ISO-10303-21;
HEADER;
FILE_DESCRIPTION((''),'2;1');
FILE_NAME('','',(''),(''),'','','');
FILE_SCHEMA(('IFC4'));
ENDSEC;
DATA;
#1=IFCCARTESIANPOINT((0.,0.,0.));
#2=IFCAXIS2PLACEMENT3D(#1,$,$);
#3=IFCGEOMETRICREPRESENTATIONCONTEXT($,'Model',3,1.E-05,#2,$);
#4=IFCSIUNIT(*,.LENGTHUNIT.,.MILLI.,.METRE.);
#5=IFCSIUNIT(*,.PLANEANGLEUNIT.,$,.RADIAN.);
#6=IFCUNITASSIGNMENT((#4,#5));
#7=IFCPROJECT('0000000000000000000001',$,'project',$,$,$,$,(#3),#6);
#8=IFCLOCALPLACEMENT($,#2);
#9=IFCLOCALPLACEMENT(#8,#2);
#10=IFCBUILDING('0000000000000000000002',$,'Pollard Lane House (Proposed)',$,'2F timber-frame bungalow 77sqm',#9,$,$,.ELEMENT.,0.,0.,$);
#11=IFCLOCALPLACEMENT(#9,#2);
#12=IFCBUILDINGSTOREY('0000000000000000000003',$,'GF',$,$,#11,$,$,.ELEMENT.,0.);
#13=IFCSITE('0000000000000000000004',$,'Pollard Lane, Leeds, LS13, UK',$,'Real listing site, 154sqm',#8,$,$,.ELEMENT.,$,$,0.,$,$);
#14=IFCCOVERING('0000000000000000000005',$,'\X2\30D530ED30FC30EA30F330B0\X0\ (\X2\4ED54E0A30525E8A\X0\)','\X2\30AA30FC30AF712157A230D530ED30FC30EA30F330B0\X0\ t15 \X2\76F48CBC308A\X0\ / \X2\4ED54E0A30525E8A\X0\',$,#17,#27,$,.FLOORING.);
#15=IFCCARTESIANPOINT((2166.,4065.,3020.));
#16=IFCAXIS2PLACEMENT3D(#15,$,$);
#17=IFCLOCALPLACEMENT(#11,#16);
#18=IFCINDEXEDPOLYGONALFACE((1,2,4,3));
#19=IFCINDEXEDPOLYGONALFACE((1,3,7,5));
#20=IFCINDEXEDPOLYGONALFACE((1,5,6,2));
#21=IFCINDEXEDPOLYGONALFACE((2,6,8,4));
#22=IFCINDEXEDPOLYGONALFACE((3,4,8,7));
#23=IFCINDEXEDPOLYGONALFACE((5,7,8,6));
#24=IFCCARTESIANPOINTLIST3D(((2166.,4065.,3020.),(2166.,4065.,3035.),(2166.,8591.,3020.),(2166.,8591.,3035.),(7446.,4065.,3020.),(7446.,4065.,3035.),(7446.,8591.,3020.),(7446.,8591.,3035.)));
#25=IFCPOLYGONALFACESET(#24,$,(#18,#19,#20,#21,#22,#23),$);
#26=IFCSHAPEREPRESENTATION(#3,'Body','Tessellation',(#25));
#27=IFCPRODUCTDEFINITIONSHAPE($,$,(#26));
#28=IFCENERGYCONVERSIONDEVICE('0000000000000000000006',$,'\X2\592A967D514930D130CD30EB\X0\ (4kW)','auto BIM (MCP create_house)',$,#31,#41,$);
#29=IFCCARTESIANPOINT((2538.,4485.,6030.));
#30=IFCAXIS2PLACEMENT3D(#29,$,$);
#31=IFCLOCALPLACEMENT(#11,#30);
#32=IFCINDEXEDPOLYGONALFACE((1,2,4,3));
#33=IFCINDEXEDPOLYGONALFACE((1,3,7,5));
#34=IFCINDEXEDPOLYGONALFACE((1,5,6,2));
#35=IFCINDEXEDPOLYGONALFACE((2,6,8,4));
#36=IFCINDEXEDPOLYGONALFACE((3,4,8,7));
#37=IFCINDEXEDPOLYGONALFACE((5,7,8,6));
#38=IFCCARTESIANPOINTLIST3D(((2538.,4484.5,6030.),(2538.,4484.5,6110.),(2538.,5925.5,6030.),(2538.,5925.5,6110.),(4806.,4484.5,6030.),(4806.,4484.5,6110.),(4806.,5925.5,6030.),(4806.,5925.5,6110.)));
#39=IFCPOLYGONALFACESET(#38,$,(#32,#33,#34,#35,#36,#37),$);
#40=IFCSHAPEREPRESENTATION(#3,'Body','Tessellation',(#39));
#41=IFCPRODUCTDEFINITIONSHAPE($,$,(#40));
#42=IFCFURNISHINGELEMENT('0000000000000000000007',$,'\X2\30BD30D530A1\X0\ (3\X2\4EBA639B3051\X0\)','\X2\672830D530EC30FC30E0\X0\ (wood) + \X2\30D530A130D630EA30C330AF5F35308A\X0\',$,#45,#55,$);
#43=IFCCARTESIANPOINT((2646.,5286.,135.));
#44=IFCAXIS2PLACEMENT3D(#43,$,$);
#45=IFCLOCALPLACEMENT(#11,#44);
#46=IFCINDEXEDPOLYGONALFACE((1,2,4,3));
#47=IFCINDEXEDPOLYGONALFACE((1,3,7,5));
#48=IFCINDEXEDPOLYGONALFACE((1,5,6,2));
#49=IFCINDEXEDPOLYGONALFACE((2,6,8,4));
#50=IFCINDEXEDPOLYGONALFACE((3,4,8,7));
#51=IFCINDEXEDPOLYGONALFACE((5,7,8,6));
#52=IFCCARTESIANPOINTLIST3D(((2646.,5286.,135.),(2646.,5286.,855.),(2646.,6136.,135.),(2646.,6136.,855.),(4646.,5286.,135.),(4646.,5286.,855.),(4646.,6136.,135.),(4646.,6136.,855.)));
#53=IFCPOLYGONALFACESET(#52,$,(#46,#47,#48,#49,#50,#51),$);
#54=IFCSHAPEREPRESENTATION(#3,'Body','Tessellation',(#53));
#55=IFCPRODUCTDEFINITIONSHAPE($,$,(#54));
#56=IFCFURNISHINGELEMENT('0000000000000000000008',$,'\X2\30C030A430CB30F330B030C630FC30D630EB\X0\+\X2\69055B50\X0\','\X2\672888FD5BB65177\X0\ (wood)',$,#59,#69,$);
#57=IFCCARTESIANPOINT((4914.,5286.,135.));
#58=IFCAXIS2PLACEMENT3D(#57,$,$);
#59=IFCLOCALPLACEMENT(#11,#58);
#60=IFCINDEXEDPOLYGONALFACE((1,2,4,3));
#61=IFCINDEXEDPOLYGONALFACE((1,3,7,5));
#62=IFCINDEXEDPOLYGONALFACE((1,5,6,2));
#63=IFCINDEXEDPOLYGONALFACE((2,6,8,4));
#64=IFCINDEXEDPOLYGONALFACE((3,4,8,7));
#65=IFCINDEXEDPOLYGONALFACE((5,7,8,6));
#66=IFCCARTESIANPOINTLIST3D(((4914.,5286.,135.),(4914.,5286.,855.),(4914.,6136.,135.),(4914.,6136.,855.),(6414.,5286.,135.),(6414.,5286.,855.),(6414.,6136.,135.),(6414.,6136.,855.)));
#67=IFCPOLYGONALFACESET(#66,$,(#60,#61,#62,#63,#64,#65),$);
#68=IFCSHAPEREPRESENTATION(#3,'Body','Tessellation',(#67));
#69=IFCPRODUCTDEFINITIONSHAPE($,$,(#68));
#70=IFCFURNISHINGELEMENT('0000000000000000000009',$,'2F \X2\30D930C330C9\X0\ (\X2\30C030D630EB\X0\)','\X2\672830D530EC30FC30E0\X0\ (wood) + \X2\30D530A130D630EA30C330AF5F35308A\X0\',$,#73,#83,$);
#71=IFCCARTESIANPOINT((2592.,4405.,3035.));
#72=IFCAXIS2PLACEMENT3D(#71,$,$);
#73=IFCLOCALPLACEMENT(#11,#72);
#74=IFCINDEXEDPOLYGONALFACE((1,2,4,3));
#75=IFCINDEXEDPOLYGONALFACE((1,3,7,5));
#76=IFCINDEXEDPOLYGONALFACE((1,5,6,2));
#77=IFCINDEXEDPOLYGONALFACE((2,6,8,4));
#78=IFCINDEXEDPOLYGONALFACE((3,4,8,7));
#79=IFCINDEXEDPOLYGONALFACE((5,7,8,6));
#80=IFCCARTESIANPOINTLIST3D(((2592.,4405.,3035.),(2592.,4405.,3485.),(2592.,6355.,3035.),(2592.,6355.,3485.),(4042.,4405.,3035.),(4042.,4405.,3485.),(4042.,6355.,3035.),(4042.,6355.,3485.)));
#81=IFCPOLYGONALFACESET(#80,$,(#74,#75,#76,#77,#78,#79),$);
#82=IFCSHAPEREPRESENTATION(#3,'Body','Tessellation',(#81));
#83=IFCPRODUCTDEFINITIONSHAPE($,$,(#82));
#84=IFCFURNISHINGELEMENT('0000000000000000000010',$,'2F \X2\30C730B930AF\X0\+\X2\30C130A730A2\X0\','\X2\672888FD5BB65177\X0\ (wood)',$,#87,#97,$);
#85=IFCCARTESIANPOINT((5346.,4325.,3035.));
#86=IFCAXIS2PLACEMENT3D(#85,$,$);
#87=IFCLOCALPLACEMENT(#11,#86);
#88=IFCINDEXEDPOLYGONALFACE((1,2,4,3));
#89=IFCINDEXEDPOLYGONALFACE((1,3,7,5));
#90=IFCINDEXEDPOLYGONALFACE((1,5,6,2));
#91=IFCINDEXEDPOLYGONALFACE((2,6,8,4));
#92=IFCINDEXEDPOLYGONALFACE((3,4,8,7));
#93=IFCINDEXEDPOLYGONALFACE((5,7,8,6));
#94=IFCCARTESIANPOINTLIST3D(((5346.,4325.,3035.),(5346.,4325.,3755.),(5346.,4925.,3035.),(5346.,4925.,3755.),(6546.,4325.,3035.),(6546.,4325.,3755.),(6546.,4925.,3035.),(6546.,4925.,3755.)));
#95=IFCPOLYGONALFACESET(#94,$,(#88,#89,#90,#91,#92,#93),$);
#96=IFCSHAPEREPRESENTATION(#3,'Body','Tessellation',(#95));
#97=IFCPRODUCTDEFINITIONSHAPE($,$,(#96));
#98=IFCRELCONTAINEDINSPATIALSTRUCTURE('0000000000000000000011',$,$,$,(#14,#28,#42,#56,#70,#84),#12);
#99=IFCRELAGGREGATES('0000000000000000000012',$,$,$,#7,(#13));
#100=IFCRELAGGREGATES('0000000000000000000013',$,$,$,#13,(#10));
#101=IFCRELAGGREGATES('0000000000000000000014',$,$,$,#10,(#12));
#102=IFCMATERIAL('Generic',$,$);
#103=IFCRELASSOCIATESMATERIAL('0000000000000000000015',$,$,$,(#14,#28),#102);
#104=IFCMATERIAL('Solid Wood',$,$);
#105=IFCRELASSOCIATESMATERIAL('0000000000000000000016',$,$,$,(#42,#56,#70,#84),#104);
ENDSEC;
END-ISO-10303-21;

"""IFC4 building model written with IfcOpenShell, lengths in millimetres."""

from ifc_helpers import new_model, si_unit, frame, frame_2d, origin, place, context, project, spatial, rectangle, extrude, material, element, save


model = new_model("IFC4")

# Units and contexts
model_context = context("Model", 3, precision=1e-05, world=origin())
ifc_project = project(units=[si_unit("LENGTHUNIT", "METRE", prefix="MILLI"), si_unit("PLANEANGLEUNIT", "RADIAN")], contexts=[model_context])

# Site, building, storey
site_placement = place(None, origin())
site = spatial("IfcSite", under=ifc_project, at=site_placement, Name="Pollard Lane, Leeds, LS13, UK", ObjectType="Real listing site, 154sqm", CompositionType="ELEMENT", RefElevation=0.0)
building_placement = place(site_placement, origin())
building = spatial("IfcBuilding", under=site, at=building_placement, Name="Pollard Lane House (Proposed)", ObjectType="2F timber-frame bungalow 77sqm", CompositionType="ELEMENT", ElevationOfRefHeight=0.0, ElevationOfTerrain=0.0)
storey_placement = place(building_placement, origin())
storey = spatial("IfcBuildingStorey", under=building, at=storey_placement, Name="GF", CompositionType="ELEMENT", Elevation=0.0)

# Shared definitions
ifc_material_1 = material(Name="Solid Wood")

# Covering
ifc_material_2 = material(Name="Generic")
covering_placement = place(storey_placement, frame((2166.0, 4065.0, 3020.0)))
element("IfcCovering", 1, at=covering_placement, inside=storey, material=ifc_material_2, Name="フローリング (仕上げ床)", Description="オーク無垢フローリング t15 直貼り / 仕上げ床", PredefinedType="FLOORING", context=model_context, shape_type="SweptSolid", body=[
    extrude(rectangle(XDim=5280.0, YDim=4526.0, at=frame_2d((2640.0, 2263.0))), frame((2166.0, 4065.0, 3020.0)), (0.0, 0.0, 1.0), 15.0),
])

# Energy conversion device
energy_conversion_device_placement = place(storey_placement, frame((2538.0, 4485.0, 6030.0)))
element("IfcEnergyConversionDevice", 2, at=energy_conversion_device_placement, inside=storey, material=ifc_material_2, Name="太陽光パネル (4kW)", Description="auto BIM (MCP create_house)", context=model_context, shape_type="SweptSolid", body=[
    extrude(rectangle(XDim=2268.0, YDim=1441.0, at=frame_2d((1134.0, 720.0))), frame((2538.0, 4485.0, 6030.0)), (0.0, 0.0, 1.0), 80.0),
])

# Furnishing elements
furnishing_1_placement = place(storey_placement, frame((2646.0, 5286.0, 135.0)))
element("IfcFurnishingElement", 3, at=furnishing_1_placement, inside=storey, material=ifc_material_1, Name="ソファ (3人掛け)", Description="木フレーム (wood) + ファブリック張り", context=model_context, shape_type="SweptSolid", body=[
    extrude(rectangle(XDim=2000.0, YDim=850.0, at=frame_2d((1000.0, 425.0))), frame((2646.0, 5286.0, 135.0)), (0.0, 0.0, 1.0), 720.0),
])
furnishing_2_placement = place(storey_placement, frame((4914.0, 5286.0, 135.0)))
element("IfcFurnishingElement", 4, at=furnishing_2_placement, inside=storey, material=ifc_material_1, Name="ダイニングテーブル+椅子", Description="木製家具 (wood)", context=model_context, shape_type="SweptSolid", body=[
    extrude(rectangle(XDim=1500.0, YDim=850.0, at=frame_2d((750.0, 425.0))), frame((4914.0, 5286.0, 135.0)), (0.0, 0.0, 1.0), 720.0),
])
furnishing_3_placement = place(storey_placement, frame((2592.0, 4405.0, 3035.0)))
element("IfcFurnishingElement", 5, at=furnishing_3_placement, inside=storey, material=ifc_material_1, Name="2F ベッド (ダブル)", Description="木フレーム (wood) + ファブリック張り", context=model_context, shape_type="SweptSolid", body=[
    extrude(rectangle(XDim=1450.0, YDim=1950.0, at=frame_2d((725.0, 975.0))), frame((2592.0, 4405.0, 3035.0)), (0.0, 0.0, 1.0), 450.0),
])
furnishing_4_placement = place(storey_placement, frame((5346.0, 4325.0, 3035.0)))
element("IfcFurnishingElement", 6, at=furnishing_4_placement, inside=storey, material=ifc_material_1, Name="2F デスク+チェア", Description="木製家具 (wood)", context=model_context, shape_type="SweptSolid", body=[
    extrude(rectangle(XDim=1200.0, YDim=600.0, at=frame_2d((600.0, 300.0))), frame((5346.0, 4325.0, 3035.0)), (0.0, 0.0, 1.0), 720.0),
])

save(model, "model.ifc")
